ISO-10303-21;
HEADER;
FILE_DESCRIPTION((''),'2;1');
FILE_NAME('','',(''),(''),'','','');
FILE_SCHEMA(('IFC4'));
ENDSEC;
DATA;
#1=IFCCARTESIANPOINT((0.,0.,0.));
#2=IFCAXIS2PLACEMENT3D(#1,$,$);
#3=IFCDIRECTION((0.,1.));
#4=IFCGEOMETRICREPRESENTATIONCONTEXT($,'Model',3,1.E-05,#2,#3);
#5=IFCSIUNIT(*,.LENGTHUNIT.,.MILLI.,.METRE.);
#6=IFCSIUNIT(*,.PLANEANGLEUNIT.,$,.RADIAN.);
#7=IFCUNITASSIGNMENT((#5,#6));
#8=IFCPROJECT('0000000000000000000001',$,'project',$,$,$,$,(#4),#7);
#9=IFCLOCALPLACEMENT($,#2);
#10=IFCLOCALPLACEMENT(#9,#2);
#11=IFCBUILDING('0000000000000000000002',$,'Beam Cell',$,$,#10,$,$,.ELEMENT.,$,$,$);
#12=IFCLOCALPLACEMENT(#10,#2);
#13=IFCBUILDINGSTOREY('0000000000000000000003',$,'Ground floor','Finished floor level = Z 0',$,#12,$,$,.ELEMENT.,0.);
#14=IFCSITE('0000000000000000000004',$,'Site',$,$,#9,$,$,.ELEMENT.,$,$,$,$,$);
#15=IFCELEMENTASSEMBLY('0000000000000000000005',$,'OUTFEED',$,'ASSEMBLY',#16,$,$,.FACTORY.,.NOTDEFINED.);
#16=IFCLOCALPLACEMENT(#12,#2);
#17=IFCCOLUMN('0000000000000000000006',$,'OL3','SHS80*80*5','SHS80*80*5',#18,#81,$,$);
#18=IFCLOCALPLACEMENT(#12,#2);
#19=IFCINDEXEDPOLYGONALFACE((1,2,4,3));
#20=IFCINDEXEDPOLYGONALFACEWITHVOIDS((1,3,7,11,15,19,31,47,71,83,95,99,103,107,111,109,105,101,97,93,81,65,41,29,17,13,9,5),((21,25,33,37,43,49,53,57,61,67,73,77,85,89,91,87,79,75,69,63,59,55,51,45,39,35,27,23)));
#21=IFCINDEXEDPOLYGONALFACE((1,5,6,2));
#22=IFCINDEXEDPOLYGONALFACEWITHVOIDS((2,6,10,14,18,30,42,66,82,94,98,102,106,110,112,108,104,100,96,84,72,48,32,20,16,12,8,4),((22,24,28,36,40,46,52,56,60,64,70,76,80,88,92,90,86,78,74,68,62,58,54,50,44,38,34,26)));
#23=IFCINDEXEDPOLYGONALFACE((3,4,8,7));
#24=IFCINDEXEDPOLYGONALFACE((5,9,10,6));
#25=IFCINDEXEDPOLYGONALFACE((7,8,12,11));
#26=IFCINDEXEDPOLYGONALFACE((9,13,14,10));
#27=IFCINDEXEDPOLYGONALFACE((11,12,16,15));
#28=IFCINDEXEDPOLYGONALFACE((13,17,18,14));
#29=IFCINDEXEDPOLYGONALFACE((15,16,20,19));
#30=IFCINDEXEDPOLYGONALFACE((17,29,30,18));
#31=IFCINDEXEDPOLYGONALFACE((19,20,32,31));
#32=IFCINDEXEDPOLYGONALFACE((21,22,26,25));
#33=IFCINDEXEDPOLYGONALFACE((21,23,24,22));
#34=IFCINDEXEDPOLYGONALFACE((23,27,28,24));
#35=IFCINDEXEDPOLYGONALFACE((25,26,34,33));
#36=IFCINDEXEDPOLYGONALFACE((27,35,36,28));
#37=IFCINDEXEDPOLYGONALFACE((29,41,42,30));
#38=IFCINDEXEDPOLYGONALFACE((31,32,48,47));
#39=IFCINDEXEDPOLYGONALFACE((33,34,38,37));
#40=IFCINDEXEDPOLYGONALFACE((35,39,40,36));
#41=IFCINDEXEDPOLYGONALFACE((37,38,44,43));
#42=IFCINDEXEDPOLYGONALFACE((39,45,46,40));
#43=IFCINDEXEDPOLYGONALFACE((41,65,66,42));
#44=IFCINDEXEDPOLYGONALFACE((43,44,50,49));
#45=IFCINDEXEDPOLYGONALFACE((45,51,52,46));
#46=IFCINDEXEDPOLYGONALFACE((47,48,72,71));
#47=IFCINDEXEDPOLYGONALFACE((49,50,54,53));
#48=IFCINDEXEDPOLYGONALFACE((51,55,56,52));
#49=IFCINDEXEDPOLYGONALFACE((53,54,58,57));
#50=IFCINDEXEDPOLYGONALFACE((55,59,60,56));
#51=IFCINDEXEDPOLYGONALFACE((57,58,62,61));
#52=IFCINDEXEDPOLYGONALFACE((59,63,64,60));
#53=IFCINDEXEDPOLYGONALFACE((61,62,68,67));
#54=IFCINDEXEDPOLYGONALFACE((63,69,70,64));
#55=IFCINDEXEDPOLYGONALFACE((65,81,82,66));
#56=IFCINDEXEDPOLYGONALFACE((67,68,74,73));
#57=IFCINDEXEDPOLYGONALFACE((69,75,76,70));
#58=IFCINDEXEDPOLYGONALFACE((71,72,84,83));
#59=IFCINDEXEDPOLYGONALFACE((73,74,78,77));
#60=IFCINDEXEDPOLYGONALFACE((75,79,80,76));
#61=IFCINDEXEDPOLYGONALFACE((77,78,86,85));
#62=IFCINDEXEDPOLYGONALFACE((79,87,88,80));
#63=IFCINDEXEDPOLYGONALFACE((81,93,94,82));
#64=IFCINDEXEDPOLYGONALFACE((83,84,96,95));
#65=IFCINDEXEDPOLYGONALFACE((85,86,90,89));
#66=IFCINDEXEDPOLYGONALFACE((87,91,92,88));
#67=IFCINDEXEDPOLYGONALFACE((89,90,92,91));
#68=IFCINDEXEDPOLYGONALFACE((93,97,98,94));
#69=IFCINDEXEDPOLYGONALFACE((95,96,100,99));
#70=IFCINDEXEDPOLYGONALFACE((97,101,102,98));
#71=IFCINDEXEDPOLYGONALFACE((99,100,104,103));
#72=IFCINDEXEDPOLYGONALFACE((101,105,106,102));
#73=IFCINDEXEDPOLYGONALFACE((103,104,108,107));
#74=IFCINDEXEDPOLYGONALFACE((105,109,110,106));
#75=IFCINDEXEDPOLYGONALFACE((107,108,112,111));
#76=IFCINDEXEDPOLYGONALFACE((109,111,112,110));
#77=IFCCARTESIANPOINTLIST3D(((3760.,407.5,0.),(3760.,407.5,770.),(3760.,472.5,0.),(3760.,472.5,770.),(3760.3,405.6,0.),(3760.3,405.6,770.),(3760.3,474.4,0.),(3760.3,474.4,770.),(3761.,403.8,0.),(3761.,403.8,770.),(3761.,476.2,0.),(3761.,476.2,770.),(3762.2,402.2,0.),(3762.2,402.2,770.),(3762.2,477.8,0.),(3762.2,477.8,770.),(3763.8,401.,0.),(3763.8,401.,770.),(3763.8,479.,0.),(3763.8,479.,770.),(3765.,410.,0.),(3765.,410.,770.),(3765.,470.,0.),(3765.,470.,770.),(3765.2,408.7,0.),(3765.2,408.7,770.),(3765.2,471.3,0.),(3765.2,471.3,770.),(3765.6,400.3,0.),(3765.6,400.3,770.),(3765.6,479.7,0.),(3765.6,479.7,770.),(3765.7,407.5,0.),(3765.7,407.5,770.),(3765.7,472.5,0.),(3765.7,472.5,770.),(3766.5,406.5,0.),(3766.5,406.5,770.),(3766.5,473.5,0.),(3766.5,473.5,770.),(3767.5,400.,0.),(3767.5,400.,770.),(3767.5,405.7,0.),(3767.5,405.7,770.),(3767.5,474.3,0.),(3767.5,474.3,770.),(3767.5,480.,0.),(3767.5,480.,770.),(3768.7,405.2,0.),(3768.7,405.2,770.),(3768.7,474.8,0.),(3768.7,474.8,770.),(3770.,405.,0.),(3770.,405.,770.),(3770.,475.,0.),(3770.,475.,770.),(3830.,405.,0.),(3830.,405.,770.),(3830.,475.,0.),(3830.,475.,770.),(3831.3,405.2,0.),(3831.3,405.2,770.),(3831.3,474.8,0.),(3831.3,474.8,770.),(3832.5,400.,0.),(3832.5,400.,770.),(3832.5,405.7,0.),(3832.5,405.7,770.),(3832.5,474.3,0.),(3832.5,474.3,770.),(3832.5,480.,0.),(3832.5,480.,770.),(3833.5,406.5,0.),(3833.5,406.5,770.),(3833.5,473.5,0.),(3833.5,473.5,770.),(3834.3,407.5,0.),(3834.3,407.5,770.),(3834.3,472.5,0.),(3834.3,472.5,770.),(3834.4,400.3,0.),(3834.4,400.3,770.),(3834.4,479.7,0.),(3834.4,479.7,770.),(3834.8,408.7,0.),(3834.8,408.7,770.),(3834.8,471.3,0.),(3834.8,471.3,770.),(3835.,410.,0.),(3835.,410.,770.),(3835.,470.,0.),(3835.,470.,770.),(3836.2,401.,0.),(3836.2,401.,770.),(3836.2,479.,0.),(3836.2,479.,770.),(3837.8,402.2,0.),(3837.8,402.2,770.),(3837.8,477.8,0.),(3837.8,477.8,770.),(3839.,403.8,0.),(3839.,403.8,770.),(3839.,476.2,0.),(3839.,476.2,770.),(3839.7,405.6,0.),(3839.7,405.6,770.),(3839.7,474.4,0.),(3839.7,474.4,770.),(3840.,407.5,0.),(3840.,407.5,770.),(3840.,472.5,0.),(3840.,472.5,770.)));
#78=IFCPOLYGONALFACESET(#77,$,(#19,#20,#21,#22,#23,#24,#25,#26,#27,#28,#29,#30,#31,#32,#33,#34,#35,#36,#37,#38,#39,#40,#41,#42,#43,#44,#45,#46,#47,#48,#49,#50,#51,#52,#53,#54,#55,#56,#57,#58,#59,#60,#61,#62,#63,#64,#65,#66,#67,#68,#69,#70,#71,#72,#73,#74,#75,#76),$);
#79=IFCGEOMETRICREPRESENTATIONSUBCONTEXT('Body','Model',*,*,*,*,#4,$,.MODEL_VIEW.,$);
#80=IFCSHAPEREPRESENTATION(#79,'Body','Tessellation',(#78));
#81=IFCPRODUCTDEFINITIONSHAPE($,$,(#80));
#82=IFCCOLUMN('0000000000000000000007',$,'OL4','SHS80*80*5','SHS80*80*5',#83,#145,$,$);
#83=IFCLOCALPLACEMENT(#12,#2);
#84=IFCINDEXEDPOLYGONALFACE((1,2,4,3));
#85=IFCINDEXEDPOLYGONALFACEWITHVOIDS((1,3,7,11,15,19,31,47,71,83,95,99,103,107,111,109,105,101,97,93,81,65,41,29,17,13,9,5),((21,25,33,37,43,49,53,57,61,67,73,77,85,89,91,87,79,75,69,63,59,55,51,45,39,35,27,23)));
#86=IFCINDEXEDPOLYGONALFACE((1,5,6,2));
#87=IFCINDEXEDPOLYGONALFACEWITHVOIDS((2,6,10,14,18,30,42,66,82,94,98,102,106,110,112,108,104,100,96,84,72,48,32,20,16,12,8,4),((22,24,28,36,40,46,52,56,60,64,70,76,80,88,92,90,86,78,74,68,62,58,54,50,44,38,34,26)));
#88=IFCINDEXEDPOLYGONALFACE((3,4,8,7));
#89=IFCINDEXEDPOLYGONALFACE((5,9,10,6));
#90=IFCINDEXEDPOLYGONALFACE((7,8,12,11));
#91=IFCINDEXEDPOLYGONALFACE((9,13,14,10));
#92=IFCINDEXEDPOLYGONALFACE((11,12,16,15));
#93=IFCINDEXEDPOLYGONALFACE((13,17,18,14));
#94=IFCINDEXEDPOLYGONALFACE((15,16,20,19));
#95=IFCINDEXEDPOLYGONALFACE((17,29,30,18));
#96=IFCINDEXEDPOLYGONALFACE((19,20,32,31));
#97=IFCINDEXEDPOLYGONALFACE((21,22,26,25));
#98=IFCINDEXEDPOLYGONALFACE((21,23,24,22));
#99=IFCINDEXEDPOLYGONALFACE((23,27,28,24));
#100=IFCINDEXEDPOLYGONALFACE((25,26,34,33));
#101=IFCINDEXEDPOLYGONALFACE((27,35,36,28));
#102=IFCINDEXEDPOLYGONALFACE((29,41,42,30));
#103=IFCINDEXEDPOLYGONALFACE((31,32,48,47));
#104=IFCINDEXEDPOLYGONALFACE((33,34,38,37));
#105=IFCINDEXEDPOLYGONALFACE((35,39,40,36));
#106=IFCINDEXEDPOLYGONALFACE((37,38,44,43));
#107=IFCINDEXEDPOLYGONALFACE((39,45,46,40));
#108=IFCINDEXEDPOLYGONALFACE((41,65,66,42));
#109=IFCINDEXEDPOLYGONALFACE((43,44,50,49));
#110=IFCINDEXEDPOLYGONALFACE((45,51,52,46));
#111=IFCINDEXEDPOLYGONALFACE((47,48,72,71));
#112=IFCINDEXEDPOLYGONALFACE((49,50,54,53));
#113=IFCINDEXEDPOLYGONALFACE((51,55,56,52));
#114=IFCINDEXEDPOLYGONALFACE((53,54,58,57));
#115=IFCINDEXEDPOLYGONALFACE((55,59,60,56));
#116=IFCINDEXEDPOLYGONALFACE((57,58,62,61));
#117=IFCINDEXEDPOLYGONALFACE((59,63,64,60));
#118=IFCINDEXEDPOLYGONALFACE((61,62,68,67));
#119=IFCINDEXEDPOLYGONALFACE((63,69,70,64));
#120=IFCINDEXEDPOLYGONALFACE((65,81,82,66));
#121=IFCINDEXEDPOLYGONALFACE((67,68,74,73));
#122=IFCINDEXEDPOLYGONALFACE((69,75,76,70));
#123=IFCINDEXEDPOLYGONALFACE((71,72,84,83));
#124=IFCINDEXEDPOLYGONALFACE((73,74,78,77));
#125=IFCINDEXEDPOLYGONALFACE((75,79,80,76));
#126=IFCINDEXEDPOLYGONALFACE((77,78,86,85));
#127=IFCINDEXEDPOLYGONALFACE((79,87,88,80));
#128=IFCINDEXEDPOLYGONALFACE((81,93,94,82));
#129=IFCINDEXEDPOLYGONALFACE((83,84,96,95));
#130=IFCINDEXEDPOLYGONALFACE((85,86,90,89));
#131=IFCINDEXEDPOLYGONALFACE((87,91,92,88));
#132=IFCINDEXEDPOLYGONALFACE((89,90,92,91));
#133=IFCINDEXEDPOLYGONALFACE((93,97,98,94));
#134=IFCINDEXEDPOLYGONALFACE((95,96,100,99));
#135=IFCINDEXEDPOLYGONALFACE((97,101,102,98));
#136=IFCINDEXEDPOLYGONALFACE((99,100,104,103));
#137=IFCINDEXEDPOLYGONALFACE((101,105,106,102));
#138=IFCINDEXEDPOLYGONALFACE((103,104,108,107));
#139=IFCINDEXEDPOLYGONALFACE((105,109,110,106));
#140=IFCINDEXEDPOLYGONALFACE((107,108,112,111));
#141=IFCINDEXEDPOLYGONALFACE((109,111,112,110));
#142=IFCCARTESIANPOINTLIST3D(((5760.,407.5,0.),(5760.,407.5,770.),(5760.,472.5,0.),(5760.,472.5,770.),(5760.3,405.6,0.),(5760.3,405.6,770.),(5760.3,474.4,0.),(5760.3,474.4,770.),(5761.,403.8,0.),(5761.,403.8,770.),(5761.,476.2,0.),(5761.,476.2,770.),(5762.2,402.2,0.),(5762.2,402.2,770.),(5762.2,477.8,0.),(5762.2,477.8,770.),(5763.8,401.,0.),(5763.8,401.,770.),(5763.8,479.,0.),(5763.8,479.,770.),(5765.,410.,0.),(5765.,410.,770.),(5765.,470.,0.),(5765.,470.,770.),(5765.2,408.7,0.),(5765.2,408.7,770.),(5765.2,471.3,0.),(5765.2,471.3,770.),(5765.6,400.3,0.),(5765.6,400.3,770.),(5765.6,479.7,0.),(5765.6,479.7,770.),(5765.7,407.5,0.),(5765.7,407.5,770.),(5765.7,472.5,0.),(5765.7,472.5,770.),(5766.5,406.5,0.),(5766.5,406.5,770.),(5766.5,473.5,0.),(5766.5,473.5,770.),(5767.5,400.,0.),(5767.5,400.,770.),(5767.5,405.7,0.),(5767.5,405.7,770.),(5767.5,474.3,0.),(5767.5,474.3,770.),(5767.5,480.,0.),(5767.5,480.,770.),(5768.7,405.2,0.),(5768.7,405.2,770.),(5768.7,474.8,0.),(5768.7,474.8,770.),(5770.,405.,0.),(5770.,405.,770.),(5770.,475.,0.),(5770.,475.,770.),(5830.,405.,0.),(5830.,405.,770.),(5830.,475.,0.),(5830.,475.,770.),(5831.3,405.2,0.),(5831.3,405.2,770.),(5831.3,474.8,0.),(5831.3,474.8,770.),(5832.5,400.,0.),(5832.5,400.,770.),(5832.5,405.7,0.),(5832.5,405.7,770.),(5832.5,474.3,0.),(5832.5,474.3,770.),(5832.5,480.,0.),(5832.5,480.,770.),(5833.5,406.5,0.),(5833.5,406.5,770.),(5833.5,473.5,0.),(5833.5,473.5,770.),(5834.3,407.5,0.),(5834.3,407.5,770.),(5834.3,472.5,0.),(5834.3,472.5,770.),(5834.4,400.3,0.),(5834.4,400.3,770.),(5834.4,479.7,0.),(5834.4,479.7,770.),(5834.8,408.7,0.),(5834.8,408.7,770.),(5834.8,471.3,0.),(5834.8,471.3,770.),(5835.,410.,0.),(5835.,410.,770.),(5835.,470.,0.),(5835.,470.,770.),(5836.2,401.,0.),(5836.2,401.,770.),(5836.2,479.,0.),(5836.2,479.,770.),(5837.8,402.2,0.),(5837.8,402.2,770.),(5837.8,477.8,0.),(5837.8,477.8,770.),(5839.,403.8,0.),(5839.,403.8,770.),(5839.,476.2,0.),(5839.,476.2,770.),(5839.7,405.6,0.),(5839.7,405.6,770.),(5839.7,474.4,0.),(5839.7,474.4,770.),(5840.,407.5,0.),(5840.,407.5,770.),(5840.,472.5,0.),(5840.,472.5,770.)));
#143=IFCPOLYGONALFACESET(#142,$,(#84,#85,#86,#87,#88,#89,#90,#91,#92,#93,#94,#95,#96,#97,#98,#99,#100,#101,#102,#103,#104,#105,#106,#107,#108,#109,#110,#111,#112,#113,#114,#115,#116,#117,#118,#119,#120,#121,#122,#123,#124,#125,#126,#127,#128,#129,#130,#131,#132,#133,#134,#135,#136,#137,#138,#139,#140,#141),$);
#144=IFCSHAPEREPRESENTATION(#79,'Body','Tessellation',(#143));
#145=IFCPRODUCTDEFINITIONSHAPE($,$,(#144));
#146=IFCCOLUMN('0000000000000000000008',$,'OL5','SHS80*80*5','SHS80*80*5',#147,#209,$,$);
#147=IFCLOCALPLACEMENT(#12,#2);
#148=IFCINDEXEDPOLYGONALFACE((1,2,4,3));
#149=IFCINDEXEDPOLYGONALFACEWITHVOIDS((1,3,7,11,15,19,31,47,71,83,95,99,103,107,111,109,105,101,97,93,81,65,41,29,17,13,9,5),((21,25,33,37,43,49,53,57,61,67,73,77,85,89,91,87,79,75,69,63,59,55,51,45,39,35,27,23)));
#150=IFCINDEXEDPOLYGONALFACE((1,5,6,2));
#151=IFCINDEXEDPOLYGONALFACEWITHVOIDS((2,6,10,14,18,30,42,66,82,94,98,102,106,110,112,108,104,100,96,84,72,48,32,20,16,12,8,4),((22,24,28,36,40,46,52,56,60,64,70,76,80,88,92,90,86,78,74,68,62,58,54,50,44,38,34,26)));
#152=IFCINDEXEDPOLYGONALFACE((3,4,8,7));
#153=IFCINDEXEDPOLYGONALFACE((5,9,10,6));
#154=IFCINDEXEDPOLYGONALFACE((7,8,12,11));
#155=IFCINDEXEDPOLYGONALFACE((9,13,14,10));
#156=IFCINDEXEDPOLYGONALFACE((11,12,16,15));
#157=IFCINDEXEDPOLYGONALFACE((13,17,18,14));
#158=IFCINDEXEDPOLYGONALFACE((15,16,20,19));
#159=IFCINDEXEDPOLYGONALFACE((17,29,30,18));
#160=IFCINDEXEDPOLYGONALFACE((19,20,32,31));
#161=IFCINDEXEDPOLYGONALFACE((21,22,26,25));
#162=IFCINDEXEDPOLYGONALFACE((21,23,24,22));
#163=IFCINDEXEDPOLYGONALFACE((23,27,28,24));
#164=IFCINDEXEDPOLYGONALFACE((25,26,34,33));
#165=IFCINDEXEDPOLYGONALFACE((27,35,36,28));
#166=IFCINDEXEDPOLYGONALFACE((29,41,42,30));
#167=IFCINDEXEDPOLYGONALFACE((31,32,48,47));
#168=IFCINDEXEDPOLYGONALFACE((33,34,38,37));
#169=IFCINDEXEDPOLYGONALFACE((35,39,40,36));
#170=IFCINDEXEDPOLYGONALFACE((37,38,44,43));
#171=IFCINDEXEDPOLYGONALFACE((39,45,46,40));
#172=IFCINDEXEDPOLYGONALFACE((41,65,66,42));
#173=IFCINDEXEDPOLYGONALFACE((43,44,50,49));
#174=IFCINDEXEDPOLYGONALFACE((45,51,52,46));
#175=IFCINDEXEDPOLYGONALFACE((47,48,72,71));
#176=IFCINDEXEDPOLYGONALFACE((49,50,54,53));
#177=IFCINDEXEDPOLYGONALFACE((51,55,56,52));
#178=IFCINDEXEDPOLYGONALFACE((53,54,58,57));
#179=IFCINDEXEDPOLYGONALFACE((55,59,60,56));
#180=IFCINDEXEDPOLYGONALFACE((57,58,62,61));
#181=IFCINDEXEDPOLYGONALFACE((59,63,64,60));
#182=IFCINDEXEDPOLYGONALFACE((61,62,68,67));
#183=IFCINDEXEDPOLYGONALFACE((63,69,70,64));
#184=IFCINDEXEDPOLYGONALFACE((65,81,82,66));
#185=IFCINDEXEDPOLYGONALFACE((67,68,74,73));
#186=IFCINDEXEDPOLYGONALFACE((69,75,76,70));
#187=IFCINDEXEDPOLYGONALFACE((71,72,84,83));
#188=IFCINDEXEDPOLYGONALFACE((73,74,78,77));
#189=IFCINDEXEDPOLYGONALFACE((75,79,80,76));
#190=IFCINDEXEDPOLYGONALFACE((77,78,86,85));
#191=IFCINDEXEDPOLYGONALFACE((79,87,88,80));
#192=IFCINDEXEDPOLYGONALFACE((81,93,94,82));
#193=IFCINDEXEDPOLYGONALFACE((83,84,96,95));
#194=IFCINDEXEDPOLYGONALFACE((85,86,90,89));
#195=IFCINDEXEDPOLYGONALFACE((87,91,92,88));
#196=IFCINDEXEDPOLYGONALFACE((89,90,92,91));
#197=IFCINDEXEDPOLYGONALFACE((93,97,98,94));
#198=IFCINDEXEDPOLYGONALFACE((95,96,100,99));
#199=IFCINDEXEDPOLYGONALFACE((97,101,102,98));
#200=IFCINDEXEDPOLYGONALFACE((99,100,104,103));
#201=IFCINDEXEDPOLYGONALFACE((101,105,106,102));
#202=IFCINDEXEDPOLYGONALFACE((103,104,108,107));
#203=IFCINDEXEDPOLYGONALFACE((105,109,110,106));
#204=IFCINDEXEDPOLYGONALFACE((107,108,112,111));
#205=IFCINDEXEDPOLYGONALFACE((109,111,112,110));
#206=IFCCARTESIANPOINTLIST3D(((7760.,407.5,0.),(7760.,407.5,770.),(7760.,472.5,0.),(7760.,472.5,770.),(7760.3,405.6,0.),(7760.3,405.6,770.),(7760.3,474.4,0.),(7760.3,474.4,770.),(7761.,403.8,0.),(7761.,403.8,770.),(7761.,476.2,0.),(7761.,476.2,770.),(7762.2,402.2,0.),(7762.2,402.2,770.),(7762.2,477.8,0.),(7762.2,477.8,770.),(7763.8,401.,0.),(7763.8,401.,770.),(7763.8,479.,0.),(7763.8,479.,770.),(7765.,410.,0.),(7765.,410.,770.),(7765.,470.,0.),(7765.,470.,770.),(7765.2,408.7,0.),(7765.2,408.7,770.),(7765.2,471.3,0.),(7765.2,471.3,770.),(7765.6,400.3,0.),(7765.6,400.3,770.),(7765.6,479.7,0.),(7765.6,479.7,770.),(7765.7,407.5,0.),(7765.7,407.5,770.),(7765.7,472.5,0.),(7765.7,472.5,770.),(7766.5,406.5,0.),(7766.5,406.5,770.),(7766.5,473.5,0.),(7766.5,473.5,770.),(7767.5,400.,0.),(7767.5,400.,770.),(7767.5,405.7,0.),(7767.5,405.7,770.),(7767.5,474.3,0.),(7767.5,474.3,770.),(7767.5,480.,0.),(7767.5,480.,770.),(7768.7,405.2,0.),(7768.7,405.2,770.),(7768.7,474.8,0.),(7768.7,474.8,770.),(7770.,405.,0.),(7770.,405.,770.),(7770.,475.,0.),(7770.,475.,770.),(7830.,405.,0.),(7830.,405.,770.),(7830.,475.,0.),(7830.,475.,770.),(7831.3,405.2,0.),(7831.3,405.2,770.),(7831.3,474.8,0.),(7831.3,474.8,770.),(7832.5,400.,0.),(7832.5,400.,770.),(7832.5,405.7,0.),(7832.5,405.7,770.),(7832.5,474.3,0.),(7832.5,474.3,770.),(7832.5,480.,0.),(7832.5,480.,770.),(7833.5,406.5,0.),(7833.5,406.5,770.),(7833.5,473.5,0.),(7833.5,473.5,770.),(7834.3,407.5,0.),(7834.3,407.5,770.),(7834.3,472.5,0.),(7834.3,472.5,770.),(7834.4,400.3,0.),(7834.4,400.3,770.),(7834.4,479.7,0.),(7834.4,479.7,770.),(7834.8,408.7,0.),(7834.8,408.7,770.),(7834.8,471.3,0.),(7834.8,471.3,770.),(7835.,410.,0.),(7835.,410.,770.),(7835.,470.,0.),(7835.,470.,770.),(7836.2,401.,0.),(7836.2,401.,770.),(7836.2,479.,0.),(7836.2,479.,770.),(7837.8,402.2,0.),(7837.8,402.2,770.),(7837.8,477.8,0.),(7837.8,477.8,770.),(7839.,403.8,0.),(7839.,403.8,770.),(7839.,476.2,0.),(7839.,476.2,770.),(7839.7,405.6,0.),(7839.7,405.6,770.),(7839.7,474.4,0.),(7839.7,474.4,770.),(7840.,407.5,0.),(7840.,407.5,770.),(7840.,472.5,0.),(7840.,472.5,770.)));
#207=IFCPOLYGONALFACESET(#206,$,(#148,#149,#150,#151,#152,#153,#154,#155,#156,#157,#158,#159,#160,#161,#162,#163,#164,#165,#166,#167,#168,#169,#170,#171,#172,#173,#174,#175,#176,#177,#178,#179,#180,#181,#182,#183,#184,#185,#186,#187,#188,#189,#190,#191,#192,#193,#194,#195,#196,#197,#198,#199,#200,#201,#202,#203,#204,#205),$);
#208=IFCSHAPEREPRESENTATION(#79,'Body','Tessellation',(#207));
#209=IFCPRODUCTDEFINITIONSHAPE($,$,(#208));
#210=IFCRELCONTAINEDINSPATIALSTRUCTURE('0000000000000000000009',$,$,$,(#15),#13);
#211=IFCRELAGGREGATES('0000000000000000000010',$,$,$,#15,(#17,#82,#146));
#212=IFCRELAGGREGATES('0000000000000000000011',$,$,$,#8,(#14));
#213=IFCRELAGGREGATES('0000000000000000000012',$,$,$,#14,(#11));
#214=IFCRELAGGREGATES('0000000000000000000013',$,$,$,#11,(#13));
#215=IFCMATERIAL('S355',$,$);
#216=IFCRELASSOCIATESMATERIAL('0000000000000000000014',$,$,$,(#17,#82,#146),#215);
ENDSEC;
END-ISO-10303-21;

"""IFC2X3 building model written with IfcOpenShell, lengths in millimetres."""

from ifc_helpers import new_model, si_unit, direction, frame, origin, origin_2d, place, context, subcontext, project, spatial, hollow_rectangle, extrude, material, element, aggregate, save


model = new_model("IFC2X3")

# Units and contexts
model_context = context("Model", 3, precision=1e-05, world=origin(), true_north=direction((0.0, 1.0)))
body_context = subcontext(model_context, "Body", "Model", "MODEL_VIEW")
ifc_project = project(units=[si_unit("LENGTHUNIT", "METRE", prefix="MILLI"), si_unit("PLANEANGLEUNIT", "RADIAN")], contexts=[model_context])

# Site, building, storey
site_placement = place(None, origin())
site = spatial("IfcSite", under=ifc_project, at=site_placement, Name="Site", CompositionType="ELEMENT")
building_placement = place(site_placement, origin())
building = spatial("IfcBuilding", under=site, at=building_placement, Name="Beam Cell", CompositionType="ELEMENT")
storey_placement = place(building_placement, origin())
storey = spatial("IfcBuildingStorey", under=building, at=storey_placement, Name="Ground floor", Description="Finished floor level = Z 0", CompositionType="ELEMENT", Elevation=0.0)

# Shared definitions
ifc_material = material(Name="S355")

# Element assembly, columns
assembly_1_placement = place(storey_placement, origin())
assembly_1 = element("IfcElementAssembly", 1, at=assembly_1_placement, inside=storey, Name="OUTFEED", ObjectType="ASSEMBLY", AssemblyPlace="FACTORY", PredefinedType="NOTDEFINED")
column_1_placement = place(storey_placement, frame((3800.0, 440.0, 0.0), z_axis=(0.0, 0.0, 1.0), x_axis=(1.0, 0.0, 0.0)))
column_1 = element("IfcColumn", 2, at=column_1_placement, material=ifc_material, Name="OL3", Description="SHS80*80*5", ObjectType="SHS80*80*5", context=body_context, shape_type="SweptSolid", body=[
    extrude(hollow_rectangle(XDim=80.0, YDim=80.0, WallThickness=5.0, InnerFilletRadius=5.0, OuterFilletRadius=7.5, at=origin_2d()), origin(), (0.0, 0.0, 1.0), 770.0),
])
column_2_placement = place(storey_placement, frame((5800.0, 440.0, 0.0), z_axis=(0.0, 0.0, 1.0), x_axis=(1.0, 0.0, 0.0)))
column_2 = element("IfcColumn", 3, at=column_2_placement, material=ifc_material, Name="OL4", Description="SHS80*80*5", ObjectType="SHS80*80*5", context=body_context, shape_type="SweptSolid", body=[
    extrude(hollow_rectangle(XDim=80.0, YDim=80.0, WallThickness=5.0, InnerFilletRadius=5.0, OuterFilletRadius=7.5, at=origin_2d()), origin(), (0.0, 0.0, 1.0), 770.0),
])
column_3_placement = place(storey_placement, frame((7800.0, 440.0, 0.0), z_axis=(0.0, 0.0, 1.0), x_axis=(1.0, 0.0, 0.0)))
column_3 = element("IfcColumn", 4, at=column_3_placement, material=ifc_material, Name="OL5", Description="SHS80*80*5", ObjectType="SHS80*80*5", context=body_context, shape_type="SweptSolid", body=[
    extrude(hollow_rectangle(XDim=80.0, YDim=80.0, WallThickness=5.0, InnerFilletRadius=5.0, OuterFilletRadius=7.5, at=origin_2d()), origin(), (0.0, 0.0, 1.0), 770.0),
])

aggregate(assembly_1, [column_1, column_2, column_3])

save(model, "model.ifc")
